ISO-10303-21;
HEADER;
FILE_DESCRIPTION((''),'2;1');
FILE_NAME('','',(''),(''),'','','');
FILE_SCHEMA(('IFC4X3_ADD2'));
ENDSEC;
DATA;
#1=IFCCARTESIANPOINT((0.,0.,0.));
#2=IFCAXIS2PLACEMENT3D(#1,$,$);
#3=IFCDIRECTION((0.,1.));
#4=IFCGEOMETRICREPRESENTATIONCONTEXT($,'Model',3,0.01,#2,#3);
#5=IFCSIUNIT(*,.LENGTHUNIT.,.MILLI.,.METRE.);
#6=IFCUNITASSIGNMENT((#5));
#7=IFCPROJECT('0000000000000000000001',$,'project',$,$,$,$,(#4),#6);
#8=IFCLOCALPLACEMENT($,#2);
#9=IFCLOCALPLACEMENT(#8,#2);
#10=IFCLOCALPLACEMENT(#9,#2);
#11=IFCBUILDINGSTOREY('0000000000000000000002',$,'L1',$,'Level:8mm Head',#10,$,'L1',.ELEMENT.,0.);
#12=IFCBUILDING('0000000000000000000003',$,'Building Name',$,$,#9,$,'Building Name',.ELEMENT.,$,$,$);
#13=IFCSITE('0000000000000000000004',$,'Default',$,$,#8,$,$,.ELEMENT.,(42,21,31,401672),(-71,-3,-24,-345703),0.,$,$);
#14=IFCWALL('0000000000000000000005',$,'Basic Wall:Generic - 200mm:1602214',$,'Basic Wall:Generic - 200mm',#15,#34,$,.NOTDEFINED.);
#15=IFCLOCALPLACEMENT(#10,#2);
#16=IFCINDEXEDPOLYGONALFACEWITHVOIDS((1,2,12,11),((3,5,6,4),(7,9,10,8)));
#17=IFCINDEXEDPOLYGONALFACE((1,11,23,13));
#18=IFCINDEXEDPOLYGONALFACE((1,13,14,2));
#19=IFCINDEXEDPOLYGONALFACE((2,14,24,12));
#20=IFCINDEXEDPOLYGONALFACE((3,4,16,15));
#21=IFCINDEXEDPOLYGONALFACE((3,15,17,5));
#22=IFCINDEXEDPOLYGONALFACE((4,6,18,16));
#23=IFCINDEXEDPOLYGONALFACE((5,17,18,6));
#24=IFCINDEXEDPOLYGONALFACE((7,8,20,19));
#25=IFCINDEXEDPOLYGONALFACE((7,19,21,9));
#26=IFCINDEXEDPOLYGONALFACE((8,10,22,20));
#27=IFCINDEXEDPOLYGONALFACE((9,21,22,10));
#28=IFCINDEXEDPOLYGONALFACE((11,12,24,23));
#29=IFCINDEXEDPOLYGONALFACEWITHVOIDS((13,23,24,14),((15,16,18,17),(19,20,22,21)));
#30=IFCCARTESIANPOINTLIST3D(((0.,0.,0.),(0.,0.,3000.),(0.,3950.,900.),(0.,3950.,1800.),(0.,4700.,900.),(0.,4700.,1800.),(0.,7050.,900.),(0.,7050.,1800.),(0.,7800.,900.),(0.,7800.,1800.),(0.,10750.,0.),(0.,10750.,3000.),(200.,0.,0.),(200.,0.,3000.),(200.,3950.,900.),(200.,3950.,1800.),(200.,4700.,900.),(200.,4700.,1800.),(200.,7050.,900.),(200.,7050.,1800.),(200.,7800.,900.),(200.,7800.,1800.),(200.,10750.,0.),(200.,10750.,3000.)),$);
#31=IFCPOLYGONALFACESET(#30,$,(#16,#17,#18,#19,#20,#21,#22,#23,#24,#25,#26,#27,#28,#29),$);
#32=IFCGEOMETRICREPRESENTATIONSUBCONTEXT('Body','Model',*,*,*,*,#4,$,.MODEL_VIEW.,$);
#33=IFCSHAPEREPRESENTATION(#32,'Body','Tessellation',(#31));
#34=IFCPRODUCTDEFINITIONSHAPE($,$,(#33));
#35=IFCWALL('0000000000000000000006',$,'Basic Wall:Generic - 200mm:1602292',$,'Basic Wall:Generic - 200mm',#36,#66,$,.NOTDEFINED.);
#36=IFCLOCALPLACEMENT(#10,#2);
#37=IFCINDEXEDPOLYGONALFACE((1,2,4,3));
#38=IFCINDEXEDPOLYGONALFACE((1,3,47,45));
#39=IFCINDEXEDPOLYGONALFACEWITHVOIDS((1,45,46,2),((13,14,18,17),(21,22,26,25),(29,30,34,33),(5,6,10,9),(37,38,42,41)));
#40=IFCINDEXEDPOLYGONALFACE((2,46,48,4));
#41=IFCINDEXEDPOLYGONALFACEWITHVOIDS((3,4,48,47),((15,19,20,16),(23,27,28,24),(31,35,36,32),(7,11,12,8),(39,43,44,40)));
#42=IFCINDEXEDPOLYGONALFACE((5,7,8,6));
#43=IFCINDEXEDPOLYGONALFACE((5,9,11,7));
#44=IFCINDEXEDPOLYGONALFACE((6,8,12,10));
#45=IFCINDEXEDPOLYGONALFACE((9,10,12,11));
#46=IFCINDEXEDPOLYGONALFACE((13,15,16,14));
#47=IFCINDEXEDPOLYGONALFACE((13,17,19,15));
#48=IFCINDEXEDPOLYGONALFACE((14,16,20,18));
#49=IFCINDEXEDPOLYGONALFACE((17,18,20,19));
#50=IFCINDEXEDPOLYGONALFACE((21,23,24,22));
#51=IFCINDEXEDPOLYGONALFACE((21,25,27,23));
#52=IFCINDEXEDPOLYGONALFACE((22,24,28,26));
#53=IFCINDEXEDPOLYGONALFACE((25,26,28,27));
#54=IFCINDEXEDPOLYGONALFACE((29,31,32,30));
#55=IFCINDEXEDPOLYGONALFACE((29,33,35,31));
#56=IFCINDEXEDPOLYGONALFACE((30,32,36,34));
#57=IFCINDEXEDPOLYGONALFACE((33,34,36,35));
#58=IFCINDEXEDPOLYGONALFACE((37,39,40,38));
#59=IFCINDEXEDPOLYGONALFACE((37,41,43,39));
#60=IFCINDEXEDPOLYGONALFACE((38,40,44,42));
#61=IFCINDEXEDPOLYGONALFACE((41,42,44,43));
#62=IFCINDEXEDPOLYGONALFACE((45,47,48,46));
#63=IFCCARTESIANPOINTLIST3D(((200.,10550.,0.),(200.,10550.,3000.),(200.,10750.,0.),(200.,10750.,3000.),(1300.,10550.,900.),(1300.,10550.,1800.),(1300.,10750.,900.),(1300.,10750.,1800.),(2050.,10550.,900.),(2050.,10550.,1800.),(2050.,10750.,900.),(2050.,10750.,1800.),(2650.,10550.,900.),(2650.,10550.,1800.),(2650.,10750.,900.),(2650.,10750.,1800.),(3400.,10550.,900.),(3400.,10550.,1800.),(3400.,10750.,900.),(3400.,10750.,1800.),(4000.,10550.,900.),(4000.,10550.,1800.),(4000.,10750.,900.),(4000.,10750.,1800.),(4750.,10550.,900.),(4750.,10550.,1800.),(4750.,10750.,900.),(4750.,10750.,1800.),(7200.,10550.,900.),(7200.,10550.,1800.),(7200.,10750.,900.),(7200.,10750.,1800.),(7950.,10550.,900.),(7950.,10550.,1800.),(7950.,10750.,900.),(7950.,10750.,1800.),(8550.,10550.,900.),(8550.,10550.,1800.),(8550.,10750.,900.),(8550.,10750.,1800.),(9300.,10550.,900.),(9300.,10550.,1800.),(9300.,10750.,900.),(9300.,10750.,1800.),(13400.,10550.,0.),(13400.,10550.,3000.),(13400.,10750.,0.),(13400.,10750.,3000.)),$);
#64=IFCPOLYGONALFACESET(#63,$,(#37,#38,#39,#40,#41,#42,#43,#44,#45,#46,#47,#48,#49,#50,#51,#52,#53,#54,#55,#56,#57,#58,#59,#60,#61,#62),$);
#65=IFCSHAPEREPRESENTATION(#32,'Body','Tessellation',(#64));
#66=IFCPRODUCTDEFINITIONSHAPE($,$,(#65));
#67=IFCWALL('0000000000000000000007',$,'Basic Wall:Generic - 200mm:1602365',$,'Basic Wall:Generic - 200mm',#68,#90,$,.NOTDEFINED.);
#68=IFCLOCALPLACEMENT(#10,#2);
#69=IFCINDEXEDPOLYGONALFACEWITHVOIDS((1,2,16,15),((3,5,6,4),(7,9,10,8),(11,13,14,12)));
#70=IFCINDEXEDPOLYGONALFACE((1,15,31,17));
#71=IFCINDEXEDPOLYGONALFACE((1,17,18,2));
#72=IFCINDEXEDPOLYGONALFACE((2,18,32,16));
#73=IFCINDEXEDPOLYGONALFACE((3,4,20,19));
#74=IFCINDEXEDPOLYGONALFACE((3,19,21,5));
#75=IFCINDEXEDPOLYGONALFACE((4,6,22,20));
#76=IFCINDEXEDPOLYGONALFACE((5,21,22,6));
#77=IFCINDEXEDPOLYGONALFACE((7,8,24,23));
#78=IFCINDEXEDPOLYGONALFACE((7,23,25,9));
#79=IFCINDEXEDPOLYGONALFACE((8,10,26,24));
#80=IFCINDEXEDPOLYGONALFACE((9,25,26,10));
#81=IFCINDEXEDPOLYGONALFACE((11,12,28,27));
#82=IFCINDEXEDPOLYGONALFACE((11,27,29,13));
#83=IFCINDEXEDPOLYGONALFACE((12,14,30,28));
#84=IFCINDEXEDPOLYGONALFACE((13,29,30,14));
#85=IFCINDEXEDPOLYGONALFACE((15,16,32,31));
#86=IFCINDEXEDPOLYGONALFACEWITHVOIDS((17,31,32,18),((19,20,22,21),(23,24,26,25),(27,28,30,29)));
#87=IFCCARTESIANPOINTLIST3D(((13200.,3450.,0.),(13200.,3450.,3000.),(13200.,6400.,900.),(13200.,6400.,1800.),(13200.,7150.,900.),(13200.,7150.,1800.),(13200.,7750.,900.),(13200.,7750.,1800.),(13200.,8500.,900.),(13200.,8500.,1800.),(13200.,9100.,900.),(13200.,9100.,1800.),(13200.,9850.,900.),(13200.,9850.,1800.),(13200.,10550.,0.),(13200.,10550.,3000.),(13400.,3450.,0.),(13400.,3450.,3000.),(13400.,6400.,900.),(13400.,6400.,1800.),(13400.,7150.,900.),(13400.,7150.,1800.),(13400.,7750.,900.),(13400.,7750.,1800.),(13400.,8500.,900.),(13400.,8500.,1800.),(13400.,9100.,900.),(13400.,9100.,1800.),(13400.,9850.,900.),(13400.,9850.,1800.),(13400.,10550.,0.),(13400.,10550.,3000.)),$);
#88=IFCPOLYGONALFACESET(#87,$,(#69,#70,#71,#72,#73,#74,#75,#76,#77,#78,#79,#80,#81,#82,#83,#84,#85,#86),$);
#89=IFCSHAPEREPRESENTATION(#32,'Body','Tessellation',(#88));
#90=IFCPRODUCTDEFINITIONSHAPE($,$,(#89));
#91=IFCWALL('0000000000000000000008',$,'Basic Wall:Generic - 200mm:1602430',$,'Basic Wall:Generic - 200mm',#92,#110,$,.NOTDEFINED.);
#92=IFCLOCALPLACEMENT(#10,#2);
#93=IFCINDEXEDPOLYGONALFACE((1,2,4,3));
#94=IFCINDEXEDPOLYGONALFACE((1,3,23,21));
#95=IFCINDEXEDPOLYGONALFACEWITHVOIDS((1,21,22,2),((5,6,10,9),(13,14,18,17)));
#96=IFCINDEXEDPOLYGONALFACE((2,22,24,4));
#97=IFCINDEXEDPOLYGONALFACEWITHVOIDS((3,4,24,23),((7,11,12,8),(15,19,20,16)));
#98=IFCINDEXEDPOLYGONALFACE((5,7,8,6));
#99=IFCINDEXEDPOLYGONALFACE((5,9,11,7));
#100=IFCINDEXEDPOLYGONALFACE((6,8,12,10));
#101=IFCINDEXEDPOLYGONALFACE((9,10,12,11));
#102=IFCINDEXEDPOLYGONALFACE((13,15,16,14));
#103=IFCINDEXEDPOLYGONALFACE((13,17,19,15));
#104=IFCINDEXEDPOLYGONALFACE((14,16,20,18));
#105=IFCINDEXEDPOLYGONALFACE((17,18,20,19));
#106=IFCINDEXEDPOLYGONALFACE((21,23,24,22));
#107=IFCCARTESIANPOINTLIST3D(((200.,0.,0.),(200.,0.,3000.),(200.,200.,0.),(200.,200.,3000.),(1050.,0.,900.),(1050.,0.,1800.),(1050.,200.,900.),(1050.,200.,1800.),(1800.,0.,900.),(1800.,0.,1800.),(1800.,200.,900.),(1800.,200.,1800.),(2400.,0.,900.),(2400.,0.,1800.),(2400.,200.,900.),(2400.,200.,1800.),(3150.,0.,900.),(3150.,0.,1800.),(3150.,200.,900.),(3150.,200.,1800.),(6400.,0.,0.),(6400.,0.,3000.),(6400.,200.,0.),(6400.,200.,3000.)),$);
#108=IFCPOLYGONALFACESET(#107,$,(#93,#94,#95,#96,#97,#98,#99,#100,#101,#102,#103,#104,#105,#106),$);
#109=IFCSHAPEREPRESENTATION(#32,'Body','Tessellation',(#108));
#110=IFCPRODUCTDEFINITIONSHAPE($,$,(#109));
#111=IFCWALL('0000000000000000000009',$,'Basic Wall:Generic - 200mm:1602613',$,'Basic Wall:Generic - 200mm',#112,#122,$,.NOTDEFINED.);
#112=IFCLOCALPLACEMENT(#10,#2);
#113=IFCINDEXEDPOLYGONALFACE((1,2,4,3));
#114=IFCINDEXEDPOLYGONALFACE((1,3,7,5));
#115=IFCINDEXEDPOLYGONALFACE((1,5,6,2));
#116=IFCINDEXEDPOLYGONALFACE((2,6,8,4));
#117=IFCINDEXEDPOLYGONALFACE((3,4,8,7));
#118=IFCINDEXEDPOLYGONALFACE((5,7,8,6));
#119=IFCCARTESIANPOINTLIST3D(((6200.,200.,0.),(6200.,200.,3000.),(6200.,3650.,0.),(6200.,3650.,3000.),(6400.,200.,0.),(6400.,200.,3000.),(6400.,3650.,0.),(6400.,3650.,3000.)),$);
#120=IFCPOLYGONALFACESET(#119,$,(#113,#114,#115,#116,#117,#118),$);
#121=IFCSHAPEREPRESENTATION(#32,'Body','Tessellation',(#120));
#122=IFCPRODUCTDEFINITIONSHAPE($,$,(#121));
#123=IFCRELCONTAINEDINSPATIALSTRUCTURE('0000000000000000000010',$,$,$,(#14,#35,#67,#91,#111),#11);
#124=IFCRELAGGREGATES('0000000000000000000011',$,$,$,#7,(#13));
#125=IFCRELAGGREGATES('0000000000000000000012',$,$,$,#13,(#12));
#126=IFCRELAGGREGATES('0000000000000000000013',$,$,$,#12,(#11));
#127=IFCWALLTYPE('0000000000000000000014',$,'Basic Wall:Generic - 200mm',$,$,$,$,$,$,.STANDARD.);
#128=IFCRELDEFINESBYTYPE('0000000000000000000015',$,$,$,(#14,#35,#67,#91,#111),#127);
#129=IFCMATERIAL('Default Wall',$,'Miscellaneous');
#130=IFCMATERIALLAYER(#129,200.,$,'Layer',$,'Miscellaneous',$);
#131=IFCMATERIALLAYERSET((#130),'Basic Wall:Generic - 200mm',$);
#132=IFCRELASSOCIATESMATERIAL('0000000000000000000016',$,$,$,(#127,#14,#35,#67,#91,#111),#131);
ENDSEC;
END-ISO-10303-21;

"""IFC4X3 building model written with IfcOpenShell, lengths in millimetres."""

from ifc_helpers import new_model, si_unit, direction, frame, frame_2d, origin, place, context, subcontext, project, spatial, rectangle, extrude, material, layer, layer_set, type_object, element, save


model = new_model("IFC4X3")

# Units and contexts
model_context = context("Model", 3, precision=0.01, world=origin(), true_north=direction((0.0, 1.0)))
body_context = subcontext(model_context, "Body", "Model", "MODEL_VIEW")
ifc_project = project(units=[si_unit("LENGTHUNIT", "METRE", prefix="MILLI")], contexts=[model_context])

# Site, building, storey
site_placement = place(None, origin())
site = spatial("IfcSite", under=ifc_project, at=site_placement, Name="Default", CompositionType="ELEMENT", RefLatitude=(42, 21, 31, 401672), RefLongitude=(-71, -3, -24, -345703), RefElevation=0.0)
building_placement = place(site_placement, origin())
building = spatial("IfcBuilding", under=site, at=building_placement, Name="Building Name", LongName="Building Name", CompositionType="ELEMENT")
storey_placement = place(building_placement, origin())
storey = spatial("IfcBuildingStorey", under=building, at=storey_placement, Name="L1", ObjectType="Level:8mm Head", LongName="L1", CompositionType="ELEMENT", Elevation=0.0)

# Walls, openings
ifc_material = material(Name="Default Wall", Category="Miscellaneous")
ifc_layer = layer(ifc_material, 200.0, Name="Layer", Category="Miscellaneous")
ifc_layer_set = layer_set([ifc_layer], Name="Basic Wall:Generic - 200mm")
wall_type = type_object("IfcWallType", Name="Basic Wall:Generic - 200mm", PredefinedType="STANDARD", material=ifc_layer_set)
wall_1_placement = place(storey_placement, frame((100.0, 0.0, 0.0), z_axis=(0.0, 0.0, 1.0), x_axis=(0.0, 1.0, 0.0)))
wall_1 = element("IfcWall", 1, at=wall_1_placement, inside=storey, type_object=wall_type, material=ifc_layer_set, Name="Basic Wall:Generic - 200mm:1602214", ObjectType="Basic Wall:Generic - 200mm", PredefinedType="NOTDEFINED", context=body_context, shape_type="SweptSolid", body=[
    extrude(rectangle(XDim=10750.0, YDim=200.0, at=frame_2d((5375.0, 0.0), x_axis=(-1.0, 0.0))), origin(), (0.0, 0.0, 1.0), 3000.0),
])
opening_1_placement = place(wall_1_placement, frame((3950.0, -100.0, 900.0)))
element("IfcOpeningElement", 2, at=opening_1_placement, cuts=wall_1, PredefinedType="OPENING", context=body_context, shape_type="SweptSolid", body=[
    extrude(rectangle(XDim=900.0, YDim=750.0, at=frame_2d((450.0, 375.0), x_axis=(-1.0, 0.0))), frame((0.0, 0.0, 0.0), z_axis=(0.0, 1.0, 0.0), x_axis=(0.0, 0.0, 1.0)), (0.0, 0.0, 1.0), 200.0),
])
opening_2_placement = place(wall_1_placement, frame((7050.0, -100.0, 900.0)))
element("IfcOpeningElement", 3, at=opening_2_placement, cuts=wall_1, PredefinedType="OPENING", context=body_context, shape_type="SweptSolid", body=[
    extrude(rectangle(XDim=900.0, YDim=750.0, at=frame_2d((450.0, 375.0), x_axis=(-1.0, 0.0))), frame((0.0, 0.0, 0.0), z_axis=(0.0, 1.0, 0.0), x_axis=(0.0, 0.0, 1.0)), (0.0, 0.0, 1.0), 200.0),
])
wall_2_placement = place(storey_placement, frame((200.0, 10650.0, 0.0)))
wall_2 = element("IfcWall", 4, at=wall_2_placement, inside=storey, type_object=wall_type, material=ifc_layer_set, Name="Basic Wall:Generic - 200mm:1602292", ObjectType="Basic Wall:Generic - 200mm", PredefinedType="NOTDEFINED", context=body_context, shape_type="SweptSolid", body=[
    extrude(rectangle(XDim=13200.0, YDim=200.0, at=frame_2d((6600.0, 0.0), x_axis=(-1.0, 0.0))), origin(), (0.0, 0.0, 1.0), 3000.0),
])
opening_3_placement = place(wall_2_placement, frame((1100.0, -100.0, 900.0)))
element("IfcOpeningElement", 5, at=opening_3_placement, cuts=wall_2, PredefinedType="OPENING", context=body_context, shape_type="SweptSolid", body=[
    extrude(rectangle(XDim=900.0, YDim=750.0, at=frame_2d((450.0, 375.0), x_axis=(-1.0, 0.0))), frame((0.0, 0.0, 0.0), z_axis=(0.0, 1.0, 0.0), x_axis=(0.0, 0.0, 1.0)), (0.0, 0.0, 1.0), 200.0),
])
opening_4_placement = place(wall_2_placement, frame((2450.0, -100.0, 900.0)))
element("IfcOpeningElement", 6, at=opening_4_placement, cuts=wall_2, PredefinedType="OPENING", context=body_context, shape_type="SweptSolid", body=[
    extrude(rectangle(XDim=900.0, YDim=750.0, at=frame_2d((450.0, 375.0), x_axis=(-1.0, 0.0))), frame((0.0, 0.0, 0.0), z_axis=(0.0, 1.0, 0.0), x_axis=(0.0, 0.0, 1.0)), (0.0, 0.0, 1.0), 200.0),
])
opening_5_placement = place(wall_2_placement, frame((3800.0, -100.0, 900.0)))
element("IfcOpeningElement", 7, at=opening_5_placement, cuts=wall_2, PredefinedType="OPENING", context=body_context, shape_type="SweptSolid", body=[
    extrude(rectangle(XDim=900.0, YDim=750.0, at=frame_2d((450.0, 375.0), x_axis=(-1.0, 0.0))), frame((0.0, 0.0, 0.0), z_axis=(0.0, 1.0, 0.0), x_axis=(0.0, 0.0, 1.0)), (0.0, 0.0, 1.0), 200.0),
])
opening_6_placement = place(wall_2_placement, frame((7000.0, -100.0, 900.0)))
element("IfcOpeningElement", 8, at=opening_6_placement, cuts=wall_2, PredefinedType="OPENING", context=body_context, shape_type="SweptSolid", body=[
    extrude(rectangle(XDim=900.0, YDim=750.0, at=frame_2d((450.0, 375.0), x_axis=(-1.0, 0.0))), frame((0.0, 0.0, 0.0), z_axis=(0.0, 1.0, 0.0), x_axis=(0.0, 0.0, 1.0)), (0.0, 0.0, 1.0), 200.0),
])
opening_7_placement = place(wall_2_placement, frame((8350.0, -100.0, 900.0)))
element("IfcOpeningElement", 9, at=opening_7_placement, cuts=wall_2, PredefinedType="OPENING", context=body_context, shape_type="SweptSolid", body=[
    extrude(rectangle(XDim=900.0, YDim=750.0, at=frame_2d((450.0, 375.0), x_axis=(-1.0, 0.0))), frame((0.0, 0.0, 0.0), z_axis=(0.0, 1.0, 0.0), x_axis=(0.0, 0.0, 1.0)), (0.0, 0.0, 1.0), 200.0),
])
wall_3_placement = place(storey_placement, frame((13300.0, 10550.0, 0.0), z_axis=(0.0, 0.0, 1.0), x_axis=(0.0, -1.0, 0.0)))
wall_3 = element("IfcWall", 10, at=wall_3_placement, inside=storey, type_object=wall_type, material=ifc_layer_set, Name="Basic Wall:Generic - 200mm:1602365", ObjectType="Basic Wall:Generic - 200mm", PredefinedType="NOTDEFINED", context=body_context, shape_type="SweptSolid", body=[
    extrude(rectangle(XDim=7100.0, YDim=200.0, at=frame_2d((3550.0, 0.0), x_axis=(-1.0, 0.0))), origin(), (0.0, 0.0, 1.0), 3000.0),
])
opening_8_placement = place(wall_3_placement, frame((700.0, -100.0, 900.0)))
element("IfcOpeningElement", 11, at=opening_8_placement, cuts=wall_3, PredefinedType="OPENING", context=body_context, shape_type="SweptSolid", body=[
    extrude(rectangle(XDim=900.0, YDim=750.0, at=frame_2d((450.0, 375.0), x_axis=(-1.0, 0.0))), frame((0.0, 0.0, 0.0), z_axis=(0.0, 1.0, 0.0), x_axis=(0.0, 0.0, 1.0)), (0.0, 0.0, 1.0), 200.0),
])
opening_9_placement = place(wall_3_placement, frame((2050.0, -100.0, 900.0)))
element("IfcOpeningElement", 12, at=opening_9_placement, cuts=wall_3, PredefinedType="OPENING", context=body_context, shape_type="SweptSolid", body=[
    extrude(rectangle(XDim=900.0, YDim=750.0, at=frame_2d((450.0, 375.0), x_axis=(-1.0, 0.0))), frame((0.0, 0.0, 0.0), z_axis=(0.0, 1.0, 0.0), x_axis=(0.0, 0.0, 1.0)), (0.0, 0.0, 1.0), 200.0),
])
opening_10_placement = place(wall_3_placement, frame((3400.0, -100.0, 900.0)))
element("IfcOpeningElement", 13, at=opening_10_placement, cuts=wall_3, PredefinedType="OPENING", context=body_context, shape_type="SweptSolid", body=[
    extrude(rectangle(XDim=900.0, YDim=750.0, at=frame_2d((450.0, 375.0), x_axis=(-1.0, 0.0))), frame((0.0, 0.0, 0.0), z_axis=(0.0, 1.0, 0.0), x_axis=(0.0, 0.0, 1.0)), (0.0, 0.0, 1.0), 200.0),
])
wall_4_placement = place(storey_placement, frame((6400.0, 100.0, 0.0), z_axis=(0.0, 0.0, 1.0), x_axis=(-1.0, 0.0, 0.0)))
wall_4 = element("IfcWall", 14, at=wall_4_placement, inside=storey, type_object=wall_type, material=ifc_layer_set, Name="Basic Wall:Generic - 200mm:1602430", ObjectType="Basic Wall:Generic - 200mm", PredefinedType="NOTDEFINED", context=body_context, shape_type="SweptSolid", body=[
    extrude(rectangle(XDim=6200.0, YDim=200.0, at=frame_2d((3100.0, 0.0), x_axis=(-1.0, 0.0))), origin(), (0.0, 0.0, 1.0), 3000.0),
])
opening_11_placement = place(wall_4_placement, frame((3250.0, -100.0, 900.0)))
element("IfcOpeningElement", 15, at=opening_11_placement, cuts=wall_4, PredefinedType="OPENING", context=body_context, shape_type="SweptSolid", body=[
    extrude(rectangle(XDim=900.0, YDim=750.0, at=frame_2d((450.0, 375.0), x_axis=(-1.0, 0.0))), frame((0.0, 0.0, 0.0), z_axis=(0.0, 1.0, 0.0), x_axis=(0.0, 0.0, 1.0)), (0.0, 0.0, 1.0), 200.0),
])
opening_12_placement = place(wall_4_placement, frame((4600.0, -100.0, 900.0)))
element("IfcOpeningElement", 16, at=opening_12_placement, cuts=wall_4, PredefinedType="OPENING", context=body_context, shape_type="SweptSolid", body=[
    extrude(rectangle(XDim=900.0, YDim=750.0, at=frame_2d((450.0, 375.0), x_axis=(-1.0, 0.0))), frame((0.0, 0.0, 0.0), z_axis=(0.0, 1.0, 0.0), x_axis=(0.0, 0.0, 1.0)), (0.0, 0.0, 1.0), 200.0),
])

# Wall
wall_5_placement = place(storey_placement, frame((6300.0, 200.0, 0.0), z_axis=(0.0, 0.0, 1.0), x_axis=(0.0, 1.0, 0.0)))
element("IfcWall", 17, at=wall_5_placement, inside=storey, type_object=wall_type, material=ifc_layer_set, Name="Basic Wall:Generic - 200mm:1602613", ObjectType="Basic Wall:Generic - 200mm", PredefinedType="NOTDEFINED", context=body_context, shape_type="SweptSolid", body=[
    extrude(rectangle(XDim=3450.0, YDim=200.0, at=frame_2d((1725.0, 0.0), x_axis=(-1.0, 0.0))), origin(), (0.0, 0.0, 1.0), 3000.0),
])

save(model, "model.ifc")
